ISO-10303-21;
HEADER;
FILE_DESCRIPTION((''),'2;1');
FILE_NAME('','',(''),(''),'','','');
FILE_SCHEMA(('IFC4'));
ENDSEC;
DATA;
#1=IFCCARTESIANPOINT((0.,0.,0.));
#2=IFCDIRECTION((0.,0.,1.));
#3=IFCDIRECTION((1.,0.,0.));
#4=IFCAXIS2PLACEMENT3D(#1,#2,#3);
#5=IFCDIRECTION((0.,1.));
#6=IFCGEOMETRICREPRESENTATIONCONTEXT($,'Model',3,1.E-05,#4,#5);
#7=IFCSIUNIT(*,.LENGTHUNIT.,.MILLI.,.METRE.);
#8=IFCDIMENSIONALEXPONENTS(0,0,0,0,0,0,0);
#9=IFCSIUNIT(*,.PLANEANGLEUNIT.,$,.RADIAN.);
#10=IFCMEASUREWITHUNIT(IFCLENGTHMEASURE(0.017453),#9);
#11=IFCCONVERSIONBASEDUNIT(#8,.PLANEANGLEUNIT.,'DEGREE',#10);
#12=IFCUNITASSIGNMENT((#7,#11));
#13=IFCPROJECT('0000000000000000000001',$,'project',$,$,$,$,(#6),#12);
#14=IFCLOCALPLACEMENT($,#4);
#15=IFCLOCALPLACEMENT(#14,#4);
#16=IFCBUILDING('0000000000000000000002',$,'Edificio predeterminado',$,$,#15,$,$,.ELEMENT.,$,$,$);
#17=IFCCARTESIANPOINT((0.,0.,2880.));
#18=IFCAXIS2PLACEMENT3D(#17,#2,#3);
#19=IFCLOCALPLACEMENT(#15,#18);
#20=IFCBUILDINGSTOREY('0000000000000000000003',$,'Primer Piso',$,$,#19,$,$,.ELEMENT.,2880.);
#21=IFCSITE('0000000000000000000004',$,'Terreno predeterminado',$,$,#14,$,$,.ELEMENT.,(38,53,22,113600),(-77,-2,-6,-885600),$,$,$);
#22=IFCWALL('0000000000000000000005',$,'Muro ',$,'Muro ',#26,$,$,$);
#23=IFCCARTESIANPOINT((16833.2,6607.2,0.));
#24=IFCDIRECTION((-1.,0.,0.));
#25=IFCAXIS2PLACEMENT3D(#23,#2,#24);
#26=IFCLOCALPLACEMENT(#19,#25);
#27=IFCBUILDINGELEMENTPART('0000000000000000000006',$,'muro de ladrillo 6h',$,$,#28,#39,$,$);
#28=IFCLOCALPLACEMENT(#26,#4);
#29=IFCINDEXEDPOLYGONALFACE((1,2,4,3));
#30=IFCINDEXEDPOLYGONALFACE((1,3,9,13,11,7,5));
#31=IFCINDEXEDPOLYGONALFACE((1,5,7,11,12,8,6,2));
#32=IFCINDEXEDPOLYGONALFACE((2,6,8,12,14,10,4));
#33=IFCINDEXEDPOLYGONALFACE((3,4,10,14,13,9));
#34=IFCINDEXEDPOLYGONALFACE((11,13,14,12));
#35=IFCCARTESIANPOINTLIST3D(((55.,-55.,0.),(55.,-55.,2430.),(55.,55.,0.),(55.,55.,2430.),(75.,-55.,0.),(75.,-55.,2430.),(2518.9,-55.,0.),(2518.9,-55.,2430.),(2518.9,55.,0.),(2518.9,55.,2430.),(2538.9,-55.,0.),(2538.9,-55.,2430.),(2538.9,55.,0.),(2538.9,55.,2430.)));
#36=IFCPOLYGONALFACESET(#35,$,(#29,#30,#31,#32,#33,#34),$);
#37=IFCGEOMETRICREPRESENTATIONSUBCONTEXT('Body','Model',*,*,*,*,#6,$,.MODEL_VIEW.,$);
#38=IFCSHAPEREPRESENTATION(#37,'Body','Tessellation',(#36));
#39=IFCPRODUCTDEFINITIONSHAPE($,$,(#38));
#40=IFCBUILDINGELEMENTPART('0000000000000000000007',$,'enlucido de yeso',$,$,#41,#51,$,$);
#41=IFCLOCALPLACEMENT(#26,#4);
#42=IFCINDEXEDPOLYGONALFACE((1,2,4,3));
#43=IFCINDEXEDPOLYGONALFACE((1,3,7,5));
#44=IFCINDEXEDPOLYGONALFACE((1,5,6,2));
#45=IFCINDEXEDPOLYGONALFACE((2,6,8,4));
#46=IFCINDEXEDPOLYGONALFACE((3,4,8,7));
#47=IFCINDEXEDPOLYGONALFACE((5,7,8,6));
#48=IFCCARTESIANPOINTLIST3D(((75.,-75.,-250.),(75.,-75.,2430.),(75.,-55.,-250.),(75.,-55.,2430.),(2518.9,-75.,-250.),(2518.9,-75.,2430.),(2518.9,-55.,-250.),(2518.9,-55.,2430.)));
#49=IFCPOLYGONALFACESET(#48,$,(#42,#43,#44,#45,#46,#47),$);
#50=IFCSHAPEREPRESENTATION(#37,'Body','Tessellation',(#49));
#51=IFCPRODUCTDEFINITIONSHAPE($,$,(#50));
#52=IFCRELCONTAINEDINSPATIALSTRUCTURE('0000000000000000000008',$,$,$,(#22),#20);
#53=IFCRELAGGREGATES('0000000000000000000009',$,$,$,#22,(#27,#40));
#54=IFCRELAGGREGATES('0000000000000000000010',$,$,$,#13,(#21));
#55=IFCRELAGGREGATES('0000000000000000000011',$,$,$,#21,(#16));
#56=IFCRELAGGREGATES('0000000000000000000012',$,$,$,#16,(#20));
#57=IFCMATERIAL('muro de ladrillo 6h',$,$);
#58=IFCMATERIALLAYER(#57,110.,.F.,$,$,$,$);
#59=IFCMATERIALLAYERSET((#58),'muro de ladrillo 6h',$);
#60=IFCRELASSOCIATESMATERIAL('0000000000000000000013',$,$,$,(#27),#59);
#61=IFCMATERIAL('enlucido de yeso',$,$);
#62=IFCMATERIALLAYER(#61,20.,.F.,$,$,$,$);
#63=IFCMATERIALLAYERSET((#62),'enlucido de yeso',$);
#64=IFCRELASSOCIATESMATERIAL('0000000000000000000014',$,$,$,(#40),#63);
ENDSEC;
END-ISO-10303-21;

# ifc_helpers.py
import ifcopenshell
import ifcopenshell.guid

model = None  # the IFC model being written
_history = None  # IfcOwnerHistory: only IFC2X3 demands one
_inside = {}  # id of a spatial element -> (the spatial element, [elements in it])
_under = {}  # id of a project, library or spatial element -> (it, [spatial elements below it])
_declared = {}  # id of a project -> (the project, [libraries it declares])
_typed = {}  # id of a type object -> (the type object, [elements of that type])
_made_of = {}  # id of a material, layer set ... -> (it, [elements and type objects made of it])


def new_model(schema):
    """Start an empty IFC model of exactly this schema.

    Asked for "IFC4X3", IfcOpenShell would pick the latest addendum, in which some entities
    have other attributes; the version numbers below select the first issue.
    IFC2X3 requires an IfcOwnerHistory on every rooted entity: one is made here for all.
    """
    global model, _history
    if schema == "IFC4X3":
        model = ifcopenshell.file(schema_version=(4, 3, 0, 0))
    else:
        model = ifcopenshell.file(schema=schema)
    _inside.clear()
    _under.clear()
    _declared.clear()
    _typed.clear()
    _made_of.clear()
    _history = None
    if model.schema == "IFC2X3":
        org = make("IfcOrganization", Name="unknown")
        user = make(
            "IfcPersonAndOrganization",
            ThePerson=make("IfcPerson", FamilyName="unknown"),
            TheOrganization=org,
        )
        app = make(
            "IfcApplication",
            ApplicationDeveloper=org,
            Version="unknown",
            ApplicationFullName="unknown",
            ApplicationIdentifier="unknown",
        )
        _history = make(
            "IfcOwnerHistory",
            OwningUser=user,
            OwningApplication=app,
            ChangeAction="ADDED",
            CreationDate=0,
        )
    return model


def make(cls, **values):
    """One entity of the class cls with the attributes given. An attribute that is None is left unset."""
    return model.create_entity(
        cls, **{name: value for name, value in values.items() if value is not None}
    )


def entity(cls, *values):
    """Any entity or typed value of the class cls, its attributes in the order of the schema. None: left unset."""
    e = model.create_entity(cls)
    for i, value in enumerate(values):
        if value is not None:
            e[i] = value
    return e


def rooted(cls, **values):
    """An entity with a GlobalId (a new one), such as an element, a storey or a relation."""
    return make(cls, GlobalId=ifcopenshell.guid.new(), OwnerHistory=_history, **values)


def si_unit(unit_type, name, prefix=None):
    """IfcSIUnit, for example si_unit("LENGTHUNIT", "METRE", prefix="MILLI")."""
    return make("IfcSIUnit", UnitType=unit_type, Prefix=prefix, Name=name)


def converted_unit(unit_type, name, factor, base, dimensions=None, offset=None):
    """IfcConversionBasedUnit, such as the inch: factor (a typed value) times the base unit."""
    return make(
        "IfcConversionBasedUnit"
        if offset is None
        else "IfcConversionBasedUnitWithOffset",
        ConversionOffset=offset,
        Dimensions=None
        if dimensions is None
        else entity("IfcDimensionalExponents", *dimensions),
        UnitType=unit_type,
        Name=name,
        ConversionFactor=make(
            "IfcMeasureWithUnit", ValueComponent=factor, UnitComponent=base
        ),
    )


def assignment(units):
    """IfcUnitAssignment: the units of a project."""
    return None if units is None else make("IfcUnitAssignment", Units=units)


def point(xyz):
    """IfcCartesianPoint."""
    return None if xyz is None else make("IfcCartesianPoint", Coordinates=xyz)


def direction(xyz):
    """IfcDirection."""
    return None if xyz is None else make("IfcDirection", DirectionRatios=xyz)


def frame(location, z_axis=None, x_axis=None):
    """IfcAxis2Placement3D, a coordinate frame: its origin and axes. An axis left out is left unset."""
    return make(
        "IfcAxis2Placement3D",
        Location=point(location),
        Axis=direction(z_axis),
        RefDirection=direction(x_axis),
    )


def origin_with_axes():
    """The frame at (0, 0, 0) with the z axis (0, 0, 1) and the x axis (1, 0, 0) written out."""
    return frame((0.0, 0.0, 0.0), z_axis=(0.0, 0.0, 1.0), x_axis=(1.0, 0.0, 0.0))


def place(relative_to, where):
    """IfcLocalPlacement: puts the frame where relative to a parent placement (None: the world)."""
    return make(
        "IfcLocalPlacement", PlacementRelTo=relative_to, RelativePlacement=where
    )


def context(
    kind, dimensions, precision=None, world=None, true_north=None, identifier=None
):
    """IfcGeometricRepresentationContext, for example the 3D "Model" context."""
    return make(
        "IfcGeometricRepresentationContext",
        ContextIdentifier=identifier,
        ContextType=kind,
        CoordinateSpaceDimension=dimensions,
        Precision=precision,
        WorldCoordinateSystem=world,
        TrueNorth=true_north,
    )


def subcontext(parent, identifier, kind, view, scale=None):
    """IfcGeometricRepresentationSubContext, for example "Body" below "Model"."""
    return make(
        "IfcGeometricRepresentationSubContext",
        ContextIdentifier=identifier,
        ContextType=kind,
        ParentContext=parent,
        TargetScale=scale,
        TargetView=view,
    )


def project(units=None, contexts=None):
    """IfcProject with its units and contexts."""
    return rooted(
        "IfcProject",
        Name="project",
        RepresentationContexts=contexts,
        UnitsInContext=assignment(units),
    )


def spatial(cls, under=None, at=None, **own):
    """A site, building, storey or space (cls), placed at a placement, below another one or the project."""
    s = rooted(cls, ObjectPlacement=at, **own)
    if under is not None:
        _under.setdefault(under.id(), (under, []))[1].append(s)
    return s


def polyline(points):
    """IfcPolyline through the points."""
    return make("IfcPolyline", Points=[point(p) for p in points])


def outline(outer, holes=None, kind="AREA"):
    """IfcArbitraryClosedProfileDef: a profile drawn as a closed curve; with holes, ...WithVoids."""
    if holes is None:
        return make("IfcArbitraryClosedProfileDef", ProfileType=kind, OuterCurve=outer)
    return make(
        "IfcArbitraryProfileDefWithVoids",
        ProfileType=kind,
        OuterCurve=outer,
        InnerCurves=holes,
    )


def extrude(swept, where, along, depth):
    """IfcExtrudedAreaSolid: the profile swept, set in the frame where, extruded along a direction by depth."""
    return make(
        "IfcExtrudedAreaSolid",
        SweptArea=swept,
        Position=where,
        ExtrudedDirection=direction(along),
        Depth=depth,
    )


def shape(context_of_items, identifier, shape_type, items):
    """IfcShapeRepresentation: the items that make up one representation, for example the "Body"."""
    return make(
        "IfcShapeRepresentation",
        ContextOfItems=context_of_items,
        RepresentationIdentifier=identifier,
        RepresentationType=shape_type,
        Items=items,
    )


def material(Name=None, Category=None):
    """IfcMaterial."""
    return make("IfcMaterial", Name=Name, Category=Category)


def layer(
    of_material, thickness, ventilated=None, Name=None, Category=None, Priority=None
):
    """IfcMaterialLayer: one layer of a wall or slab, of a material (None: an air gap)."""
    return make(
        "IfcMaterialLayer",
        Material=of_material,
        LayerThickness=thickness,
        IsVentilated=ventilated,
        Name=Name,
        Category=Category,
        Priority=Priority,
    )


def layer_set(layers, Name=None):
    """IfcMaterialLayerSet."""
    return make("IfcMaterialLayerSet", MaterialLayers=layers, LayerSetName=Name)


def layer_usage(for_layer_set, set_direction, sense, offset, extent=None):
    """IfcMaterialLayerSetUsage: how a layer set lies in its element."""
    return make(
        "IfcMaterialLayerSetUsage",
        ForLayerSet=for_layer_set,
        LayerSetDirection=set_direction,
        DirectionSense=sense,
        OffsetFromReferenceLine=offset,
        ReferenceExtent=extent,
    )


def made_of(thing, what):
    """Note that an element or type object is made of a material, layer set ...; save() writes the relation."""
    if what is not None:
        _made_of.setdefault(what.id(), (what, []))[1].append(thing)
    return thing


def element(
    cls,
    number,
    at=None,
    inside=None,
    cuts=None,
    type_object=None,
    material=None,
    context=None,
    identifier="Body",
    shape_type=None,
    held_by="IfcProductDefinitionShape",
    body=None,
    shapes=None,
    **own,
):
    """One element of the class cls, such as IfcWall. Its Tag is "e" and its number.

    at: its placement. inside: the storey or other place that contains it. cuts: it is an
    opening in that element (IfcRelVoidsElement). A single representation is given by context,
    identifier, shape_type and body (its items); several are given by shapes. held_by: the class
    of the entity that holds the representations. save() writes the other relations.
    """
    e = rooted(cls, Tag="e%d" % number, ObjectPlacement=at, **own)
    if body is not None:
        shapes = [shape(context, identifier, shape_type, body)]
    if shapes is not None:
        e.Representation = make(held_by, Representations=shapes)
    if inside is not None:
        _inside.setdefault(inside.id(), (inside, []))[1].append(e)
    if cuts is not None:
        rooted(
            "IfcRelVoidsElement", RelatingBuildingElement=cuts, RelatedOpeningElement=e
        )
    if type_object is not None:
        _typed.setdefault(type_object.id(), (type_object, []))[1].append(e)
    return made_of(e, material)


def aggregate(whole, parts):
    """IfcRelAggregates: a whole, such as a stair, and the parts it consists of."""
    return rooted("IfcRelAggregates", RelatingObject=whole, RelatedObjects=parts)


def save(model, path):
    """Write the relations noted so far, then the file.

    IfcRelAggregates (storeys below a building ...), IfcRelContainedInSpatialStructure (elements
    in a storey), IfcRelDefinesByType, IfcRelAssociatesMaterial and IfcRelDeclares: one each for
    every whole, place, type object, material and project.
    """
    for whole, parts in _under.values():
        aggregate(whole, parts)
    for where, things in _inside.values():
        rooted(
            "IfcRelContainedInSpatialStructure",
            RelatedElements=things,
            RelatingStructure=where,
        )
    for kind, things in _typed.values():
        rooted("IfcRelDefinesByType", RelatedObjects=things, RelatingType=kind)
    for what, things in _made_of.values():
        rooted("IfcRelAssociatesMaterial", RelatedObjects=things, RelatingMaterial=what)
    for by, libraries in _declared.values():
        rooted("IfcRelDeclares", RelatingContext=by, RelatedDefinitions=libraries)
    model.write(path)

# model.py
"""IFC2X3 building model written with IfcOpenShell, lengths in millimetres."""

from ifc_helpers import new_model, entity, si_unit, converted_unit, direction, frame, origin_with_axes, place, context, subcontext, project, spatial, polyline, outline, extrude, material, layer, layer_set, layer_usage, element, aggregate, save


model = new_model("IFC2X3")

# Units and contexts
model_context = context("Model", 3, precision=1e-05, world=origin_with_axes(), true_north=direction((0.0, 1.0)))
body_context = subcontext(model_context, "Body", "Model", "MODEL_VIEW")
ifc_project = project(units=[si_unit("LENGTHUNIT", "METRE", prefix="MILLI"), converted_unit("PLANEANGLEUNIT", "DEGREE", entity("IfcLengthMeasure", 0.017453), si_unit("PLANEANGLEUNIT", "RADIAN"), dimensions=[0, 0, 0, 0, 0, 0, 0])], contexts=[model_context])

# Site, building, storey
site_placement = place(None, origin_with_axes())
site = spatial("IfcSite", under=ifc_project, at=site_placement, Name="Terreno predeterminado", CompositionType="ELEMENT", RefLatitude=(38, 53, 22, 113600), RefLongitude=(-77, -2, -6, -885600))
building_placement = place(site_placement, origin_with_axes())
building = spatial("IfcBuilding", under=site, at=building_placement, Name="Edificio predeterminado", CompositionType="ELEMENT")
storey_placement = place(building_placement, frame((0.0, 0.0, 2880.0), z_axis=(0.0, 0.0, 1.0), x_axis=(1.0, 0.0, 0.0)))
storey = spatial("IfcBuildingStorey", under=building, at=storey_placement, Name="Primer Piso", CompositionType="ELEMENT", Elevation=2880.0)

# Wall, building element parts
wall_1_placement = place(storey_placement, frame((16833.2, 6607.2, 0.0), z_axis=(0.0, 0.0, 1.0), x_axis=(-1.0, 0.0, 0.0)))
wall_1 = element("IfcWall", 1, at=wall_1_placement, inside=storey, Name="Muro ", ObjectType="Muro ")
ifc_material_1 = material(Name="muro de ladrillo 6h")
ifc_layer_1 = layer(ifc_material_1, 110.0, ventilated=False)
ifc_layer_set_1 = layer_set([ifc_layer_1], Name="muro de ladrillo 6h")
ifc_layer_usage_1 = layer_usage(ifc_layer_set_1, "AXIS2", "NEGATIVE", -55.0)
building_element_part_1_placement = place(wall_1_placement, origin_with_axes())
building_element_part_1 = element("IfcBuildingElementPart", 2, at=building_element_part_1_placement, material=ifc_layer_usage_1, Name="muro de ladrillo 6h", context=body_context, shape_type="SweptSolid", body=[
    extrude(outline(polyline([(2538.9, 55.0), (2538.9, -55.0), (2518.9, -55.0), (75.0, -55.0), (55.0, -55.0), (55.0, 55.0), (2518.9, 55.0), (2538.9, 55.0)])), origin_with_axes(), (0.0, 0.0, 1.0), 2430.0),
])
ifc_material_2 = material(Name="enlucido de yeso")
ifc_layer_2 = layer(ifc_material_2, 20.0, ventilated=False)
ifc_layer_set_2 = layer_set([ifc_layer_2], Name="enlucido de yeso")
ifc_layer_usage_2 = layer_usage(ifc_layer_set_2, "AXIS2", "NEGATIVE", 55.0)
building_element_part_2_placement = place(wall_1_placement, origin_with_axes())
building_element_part_2 = element("IfcBuildingElementPart", 3, at=building_element_part_2_placement, material=ifc_layer_usage_2, Name="enlucido de yeso", context=body_context, shape_type="SweptSolid", body=[
    extrude(outline(polyline([(2518.9, -55.0), (2518.9, -75.0), (75.0, -75.0), (75.0, -55.0), (2518.9, -55.0)])), frame((0.0, 0.0, -250.0), z_axis=(0.0, 0.0, 1.0), x_axis=(1.0, 0.0, 0.0)), (0.0, 0.0, 1.0), 2680.0),
])
aggregate(wall_1, [building_element_part_1, building_element_part_2])

save(model, "model.ifc")
